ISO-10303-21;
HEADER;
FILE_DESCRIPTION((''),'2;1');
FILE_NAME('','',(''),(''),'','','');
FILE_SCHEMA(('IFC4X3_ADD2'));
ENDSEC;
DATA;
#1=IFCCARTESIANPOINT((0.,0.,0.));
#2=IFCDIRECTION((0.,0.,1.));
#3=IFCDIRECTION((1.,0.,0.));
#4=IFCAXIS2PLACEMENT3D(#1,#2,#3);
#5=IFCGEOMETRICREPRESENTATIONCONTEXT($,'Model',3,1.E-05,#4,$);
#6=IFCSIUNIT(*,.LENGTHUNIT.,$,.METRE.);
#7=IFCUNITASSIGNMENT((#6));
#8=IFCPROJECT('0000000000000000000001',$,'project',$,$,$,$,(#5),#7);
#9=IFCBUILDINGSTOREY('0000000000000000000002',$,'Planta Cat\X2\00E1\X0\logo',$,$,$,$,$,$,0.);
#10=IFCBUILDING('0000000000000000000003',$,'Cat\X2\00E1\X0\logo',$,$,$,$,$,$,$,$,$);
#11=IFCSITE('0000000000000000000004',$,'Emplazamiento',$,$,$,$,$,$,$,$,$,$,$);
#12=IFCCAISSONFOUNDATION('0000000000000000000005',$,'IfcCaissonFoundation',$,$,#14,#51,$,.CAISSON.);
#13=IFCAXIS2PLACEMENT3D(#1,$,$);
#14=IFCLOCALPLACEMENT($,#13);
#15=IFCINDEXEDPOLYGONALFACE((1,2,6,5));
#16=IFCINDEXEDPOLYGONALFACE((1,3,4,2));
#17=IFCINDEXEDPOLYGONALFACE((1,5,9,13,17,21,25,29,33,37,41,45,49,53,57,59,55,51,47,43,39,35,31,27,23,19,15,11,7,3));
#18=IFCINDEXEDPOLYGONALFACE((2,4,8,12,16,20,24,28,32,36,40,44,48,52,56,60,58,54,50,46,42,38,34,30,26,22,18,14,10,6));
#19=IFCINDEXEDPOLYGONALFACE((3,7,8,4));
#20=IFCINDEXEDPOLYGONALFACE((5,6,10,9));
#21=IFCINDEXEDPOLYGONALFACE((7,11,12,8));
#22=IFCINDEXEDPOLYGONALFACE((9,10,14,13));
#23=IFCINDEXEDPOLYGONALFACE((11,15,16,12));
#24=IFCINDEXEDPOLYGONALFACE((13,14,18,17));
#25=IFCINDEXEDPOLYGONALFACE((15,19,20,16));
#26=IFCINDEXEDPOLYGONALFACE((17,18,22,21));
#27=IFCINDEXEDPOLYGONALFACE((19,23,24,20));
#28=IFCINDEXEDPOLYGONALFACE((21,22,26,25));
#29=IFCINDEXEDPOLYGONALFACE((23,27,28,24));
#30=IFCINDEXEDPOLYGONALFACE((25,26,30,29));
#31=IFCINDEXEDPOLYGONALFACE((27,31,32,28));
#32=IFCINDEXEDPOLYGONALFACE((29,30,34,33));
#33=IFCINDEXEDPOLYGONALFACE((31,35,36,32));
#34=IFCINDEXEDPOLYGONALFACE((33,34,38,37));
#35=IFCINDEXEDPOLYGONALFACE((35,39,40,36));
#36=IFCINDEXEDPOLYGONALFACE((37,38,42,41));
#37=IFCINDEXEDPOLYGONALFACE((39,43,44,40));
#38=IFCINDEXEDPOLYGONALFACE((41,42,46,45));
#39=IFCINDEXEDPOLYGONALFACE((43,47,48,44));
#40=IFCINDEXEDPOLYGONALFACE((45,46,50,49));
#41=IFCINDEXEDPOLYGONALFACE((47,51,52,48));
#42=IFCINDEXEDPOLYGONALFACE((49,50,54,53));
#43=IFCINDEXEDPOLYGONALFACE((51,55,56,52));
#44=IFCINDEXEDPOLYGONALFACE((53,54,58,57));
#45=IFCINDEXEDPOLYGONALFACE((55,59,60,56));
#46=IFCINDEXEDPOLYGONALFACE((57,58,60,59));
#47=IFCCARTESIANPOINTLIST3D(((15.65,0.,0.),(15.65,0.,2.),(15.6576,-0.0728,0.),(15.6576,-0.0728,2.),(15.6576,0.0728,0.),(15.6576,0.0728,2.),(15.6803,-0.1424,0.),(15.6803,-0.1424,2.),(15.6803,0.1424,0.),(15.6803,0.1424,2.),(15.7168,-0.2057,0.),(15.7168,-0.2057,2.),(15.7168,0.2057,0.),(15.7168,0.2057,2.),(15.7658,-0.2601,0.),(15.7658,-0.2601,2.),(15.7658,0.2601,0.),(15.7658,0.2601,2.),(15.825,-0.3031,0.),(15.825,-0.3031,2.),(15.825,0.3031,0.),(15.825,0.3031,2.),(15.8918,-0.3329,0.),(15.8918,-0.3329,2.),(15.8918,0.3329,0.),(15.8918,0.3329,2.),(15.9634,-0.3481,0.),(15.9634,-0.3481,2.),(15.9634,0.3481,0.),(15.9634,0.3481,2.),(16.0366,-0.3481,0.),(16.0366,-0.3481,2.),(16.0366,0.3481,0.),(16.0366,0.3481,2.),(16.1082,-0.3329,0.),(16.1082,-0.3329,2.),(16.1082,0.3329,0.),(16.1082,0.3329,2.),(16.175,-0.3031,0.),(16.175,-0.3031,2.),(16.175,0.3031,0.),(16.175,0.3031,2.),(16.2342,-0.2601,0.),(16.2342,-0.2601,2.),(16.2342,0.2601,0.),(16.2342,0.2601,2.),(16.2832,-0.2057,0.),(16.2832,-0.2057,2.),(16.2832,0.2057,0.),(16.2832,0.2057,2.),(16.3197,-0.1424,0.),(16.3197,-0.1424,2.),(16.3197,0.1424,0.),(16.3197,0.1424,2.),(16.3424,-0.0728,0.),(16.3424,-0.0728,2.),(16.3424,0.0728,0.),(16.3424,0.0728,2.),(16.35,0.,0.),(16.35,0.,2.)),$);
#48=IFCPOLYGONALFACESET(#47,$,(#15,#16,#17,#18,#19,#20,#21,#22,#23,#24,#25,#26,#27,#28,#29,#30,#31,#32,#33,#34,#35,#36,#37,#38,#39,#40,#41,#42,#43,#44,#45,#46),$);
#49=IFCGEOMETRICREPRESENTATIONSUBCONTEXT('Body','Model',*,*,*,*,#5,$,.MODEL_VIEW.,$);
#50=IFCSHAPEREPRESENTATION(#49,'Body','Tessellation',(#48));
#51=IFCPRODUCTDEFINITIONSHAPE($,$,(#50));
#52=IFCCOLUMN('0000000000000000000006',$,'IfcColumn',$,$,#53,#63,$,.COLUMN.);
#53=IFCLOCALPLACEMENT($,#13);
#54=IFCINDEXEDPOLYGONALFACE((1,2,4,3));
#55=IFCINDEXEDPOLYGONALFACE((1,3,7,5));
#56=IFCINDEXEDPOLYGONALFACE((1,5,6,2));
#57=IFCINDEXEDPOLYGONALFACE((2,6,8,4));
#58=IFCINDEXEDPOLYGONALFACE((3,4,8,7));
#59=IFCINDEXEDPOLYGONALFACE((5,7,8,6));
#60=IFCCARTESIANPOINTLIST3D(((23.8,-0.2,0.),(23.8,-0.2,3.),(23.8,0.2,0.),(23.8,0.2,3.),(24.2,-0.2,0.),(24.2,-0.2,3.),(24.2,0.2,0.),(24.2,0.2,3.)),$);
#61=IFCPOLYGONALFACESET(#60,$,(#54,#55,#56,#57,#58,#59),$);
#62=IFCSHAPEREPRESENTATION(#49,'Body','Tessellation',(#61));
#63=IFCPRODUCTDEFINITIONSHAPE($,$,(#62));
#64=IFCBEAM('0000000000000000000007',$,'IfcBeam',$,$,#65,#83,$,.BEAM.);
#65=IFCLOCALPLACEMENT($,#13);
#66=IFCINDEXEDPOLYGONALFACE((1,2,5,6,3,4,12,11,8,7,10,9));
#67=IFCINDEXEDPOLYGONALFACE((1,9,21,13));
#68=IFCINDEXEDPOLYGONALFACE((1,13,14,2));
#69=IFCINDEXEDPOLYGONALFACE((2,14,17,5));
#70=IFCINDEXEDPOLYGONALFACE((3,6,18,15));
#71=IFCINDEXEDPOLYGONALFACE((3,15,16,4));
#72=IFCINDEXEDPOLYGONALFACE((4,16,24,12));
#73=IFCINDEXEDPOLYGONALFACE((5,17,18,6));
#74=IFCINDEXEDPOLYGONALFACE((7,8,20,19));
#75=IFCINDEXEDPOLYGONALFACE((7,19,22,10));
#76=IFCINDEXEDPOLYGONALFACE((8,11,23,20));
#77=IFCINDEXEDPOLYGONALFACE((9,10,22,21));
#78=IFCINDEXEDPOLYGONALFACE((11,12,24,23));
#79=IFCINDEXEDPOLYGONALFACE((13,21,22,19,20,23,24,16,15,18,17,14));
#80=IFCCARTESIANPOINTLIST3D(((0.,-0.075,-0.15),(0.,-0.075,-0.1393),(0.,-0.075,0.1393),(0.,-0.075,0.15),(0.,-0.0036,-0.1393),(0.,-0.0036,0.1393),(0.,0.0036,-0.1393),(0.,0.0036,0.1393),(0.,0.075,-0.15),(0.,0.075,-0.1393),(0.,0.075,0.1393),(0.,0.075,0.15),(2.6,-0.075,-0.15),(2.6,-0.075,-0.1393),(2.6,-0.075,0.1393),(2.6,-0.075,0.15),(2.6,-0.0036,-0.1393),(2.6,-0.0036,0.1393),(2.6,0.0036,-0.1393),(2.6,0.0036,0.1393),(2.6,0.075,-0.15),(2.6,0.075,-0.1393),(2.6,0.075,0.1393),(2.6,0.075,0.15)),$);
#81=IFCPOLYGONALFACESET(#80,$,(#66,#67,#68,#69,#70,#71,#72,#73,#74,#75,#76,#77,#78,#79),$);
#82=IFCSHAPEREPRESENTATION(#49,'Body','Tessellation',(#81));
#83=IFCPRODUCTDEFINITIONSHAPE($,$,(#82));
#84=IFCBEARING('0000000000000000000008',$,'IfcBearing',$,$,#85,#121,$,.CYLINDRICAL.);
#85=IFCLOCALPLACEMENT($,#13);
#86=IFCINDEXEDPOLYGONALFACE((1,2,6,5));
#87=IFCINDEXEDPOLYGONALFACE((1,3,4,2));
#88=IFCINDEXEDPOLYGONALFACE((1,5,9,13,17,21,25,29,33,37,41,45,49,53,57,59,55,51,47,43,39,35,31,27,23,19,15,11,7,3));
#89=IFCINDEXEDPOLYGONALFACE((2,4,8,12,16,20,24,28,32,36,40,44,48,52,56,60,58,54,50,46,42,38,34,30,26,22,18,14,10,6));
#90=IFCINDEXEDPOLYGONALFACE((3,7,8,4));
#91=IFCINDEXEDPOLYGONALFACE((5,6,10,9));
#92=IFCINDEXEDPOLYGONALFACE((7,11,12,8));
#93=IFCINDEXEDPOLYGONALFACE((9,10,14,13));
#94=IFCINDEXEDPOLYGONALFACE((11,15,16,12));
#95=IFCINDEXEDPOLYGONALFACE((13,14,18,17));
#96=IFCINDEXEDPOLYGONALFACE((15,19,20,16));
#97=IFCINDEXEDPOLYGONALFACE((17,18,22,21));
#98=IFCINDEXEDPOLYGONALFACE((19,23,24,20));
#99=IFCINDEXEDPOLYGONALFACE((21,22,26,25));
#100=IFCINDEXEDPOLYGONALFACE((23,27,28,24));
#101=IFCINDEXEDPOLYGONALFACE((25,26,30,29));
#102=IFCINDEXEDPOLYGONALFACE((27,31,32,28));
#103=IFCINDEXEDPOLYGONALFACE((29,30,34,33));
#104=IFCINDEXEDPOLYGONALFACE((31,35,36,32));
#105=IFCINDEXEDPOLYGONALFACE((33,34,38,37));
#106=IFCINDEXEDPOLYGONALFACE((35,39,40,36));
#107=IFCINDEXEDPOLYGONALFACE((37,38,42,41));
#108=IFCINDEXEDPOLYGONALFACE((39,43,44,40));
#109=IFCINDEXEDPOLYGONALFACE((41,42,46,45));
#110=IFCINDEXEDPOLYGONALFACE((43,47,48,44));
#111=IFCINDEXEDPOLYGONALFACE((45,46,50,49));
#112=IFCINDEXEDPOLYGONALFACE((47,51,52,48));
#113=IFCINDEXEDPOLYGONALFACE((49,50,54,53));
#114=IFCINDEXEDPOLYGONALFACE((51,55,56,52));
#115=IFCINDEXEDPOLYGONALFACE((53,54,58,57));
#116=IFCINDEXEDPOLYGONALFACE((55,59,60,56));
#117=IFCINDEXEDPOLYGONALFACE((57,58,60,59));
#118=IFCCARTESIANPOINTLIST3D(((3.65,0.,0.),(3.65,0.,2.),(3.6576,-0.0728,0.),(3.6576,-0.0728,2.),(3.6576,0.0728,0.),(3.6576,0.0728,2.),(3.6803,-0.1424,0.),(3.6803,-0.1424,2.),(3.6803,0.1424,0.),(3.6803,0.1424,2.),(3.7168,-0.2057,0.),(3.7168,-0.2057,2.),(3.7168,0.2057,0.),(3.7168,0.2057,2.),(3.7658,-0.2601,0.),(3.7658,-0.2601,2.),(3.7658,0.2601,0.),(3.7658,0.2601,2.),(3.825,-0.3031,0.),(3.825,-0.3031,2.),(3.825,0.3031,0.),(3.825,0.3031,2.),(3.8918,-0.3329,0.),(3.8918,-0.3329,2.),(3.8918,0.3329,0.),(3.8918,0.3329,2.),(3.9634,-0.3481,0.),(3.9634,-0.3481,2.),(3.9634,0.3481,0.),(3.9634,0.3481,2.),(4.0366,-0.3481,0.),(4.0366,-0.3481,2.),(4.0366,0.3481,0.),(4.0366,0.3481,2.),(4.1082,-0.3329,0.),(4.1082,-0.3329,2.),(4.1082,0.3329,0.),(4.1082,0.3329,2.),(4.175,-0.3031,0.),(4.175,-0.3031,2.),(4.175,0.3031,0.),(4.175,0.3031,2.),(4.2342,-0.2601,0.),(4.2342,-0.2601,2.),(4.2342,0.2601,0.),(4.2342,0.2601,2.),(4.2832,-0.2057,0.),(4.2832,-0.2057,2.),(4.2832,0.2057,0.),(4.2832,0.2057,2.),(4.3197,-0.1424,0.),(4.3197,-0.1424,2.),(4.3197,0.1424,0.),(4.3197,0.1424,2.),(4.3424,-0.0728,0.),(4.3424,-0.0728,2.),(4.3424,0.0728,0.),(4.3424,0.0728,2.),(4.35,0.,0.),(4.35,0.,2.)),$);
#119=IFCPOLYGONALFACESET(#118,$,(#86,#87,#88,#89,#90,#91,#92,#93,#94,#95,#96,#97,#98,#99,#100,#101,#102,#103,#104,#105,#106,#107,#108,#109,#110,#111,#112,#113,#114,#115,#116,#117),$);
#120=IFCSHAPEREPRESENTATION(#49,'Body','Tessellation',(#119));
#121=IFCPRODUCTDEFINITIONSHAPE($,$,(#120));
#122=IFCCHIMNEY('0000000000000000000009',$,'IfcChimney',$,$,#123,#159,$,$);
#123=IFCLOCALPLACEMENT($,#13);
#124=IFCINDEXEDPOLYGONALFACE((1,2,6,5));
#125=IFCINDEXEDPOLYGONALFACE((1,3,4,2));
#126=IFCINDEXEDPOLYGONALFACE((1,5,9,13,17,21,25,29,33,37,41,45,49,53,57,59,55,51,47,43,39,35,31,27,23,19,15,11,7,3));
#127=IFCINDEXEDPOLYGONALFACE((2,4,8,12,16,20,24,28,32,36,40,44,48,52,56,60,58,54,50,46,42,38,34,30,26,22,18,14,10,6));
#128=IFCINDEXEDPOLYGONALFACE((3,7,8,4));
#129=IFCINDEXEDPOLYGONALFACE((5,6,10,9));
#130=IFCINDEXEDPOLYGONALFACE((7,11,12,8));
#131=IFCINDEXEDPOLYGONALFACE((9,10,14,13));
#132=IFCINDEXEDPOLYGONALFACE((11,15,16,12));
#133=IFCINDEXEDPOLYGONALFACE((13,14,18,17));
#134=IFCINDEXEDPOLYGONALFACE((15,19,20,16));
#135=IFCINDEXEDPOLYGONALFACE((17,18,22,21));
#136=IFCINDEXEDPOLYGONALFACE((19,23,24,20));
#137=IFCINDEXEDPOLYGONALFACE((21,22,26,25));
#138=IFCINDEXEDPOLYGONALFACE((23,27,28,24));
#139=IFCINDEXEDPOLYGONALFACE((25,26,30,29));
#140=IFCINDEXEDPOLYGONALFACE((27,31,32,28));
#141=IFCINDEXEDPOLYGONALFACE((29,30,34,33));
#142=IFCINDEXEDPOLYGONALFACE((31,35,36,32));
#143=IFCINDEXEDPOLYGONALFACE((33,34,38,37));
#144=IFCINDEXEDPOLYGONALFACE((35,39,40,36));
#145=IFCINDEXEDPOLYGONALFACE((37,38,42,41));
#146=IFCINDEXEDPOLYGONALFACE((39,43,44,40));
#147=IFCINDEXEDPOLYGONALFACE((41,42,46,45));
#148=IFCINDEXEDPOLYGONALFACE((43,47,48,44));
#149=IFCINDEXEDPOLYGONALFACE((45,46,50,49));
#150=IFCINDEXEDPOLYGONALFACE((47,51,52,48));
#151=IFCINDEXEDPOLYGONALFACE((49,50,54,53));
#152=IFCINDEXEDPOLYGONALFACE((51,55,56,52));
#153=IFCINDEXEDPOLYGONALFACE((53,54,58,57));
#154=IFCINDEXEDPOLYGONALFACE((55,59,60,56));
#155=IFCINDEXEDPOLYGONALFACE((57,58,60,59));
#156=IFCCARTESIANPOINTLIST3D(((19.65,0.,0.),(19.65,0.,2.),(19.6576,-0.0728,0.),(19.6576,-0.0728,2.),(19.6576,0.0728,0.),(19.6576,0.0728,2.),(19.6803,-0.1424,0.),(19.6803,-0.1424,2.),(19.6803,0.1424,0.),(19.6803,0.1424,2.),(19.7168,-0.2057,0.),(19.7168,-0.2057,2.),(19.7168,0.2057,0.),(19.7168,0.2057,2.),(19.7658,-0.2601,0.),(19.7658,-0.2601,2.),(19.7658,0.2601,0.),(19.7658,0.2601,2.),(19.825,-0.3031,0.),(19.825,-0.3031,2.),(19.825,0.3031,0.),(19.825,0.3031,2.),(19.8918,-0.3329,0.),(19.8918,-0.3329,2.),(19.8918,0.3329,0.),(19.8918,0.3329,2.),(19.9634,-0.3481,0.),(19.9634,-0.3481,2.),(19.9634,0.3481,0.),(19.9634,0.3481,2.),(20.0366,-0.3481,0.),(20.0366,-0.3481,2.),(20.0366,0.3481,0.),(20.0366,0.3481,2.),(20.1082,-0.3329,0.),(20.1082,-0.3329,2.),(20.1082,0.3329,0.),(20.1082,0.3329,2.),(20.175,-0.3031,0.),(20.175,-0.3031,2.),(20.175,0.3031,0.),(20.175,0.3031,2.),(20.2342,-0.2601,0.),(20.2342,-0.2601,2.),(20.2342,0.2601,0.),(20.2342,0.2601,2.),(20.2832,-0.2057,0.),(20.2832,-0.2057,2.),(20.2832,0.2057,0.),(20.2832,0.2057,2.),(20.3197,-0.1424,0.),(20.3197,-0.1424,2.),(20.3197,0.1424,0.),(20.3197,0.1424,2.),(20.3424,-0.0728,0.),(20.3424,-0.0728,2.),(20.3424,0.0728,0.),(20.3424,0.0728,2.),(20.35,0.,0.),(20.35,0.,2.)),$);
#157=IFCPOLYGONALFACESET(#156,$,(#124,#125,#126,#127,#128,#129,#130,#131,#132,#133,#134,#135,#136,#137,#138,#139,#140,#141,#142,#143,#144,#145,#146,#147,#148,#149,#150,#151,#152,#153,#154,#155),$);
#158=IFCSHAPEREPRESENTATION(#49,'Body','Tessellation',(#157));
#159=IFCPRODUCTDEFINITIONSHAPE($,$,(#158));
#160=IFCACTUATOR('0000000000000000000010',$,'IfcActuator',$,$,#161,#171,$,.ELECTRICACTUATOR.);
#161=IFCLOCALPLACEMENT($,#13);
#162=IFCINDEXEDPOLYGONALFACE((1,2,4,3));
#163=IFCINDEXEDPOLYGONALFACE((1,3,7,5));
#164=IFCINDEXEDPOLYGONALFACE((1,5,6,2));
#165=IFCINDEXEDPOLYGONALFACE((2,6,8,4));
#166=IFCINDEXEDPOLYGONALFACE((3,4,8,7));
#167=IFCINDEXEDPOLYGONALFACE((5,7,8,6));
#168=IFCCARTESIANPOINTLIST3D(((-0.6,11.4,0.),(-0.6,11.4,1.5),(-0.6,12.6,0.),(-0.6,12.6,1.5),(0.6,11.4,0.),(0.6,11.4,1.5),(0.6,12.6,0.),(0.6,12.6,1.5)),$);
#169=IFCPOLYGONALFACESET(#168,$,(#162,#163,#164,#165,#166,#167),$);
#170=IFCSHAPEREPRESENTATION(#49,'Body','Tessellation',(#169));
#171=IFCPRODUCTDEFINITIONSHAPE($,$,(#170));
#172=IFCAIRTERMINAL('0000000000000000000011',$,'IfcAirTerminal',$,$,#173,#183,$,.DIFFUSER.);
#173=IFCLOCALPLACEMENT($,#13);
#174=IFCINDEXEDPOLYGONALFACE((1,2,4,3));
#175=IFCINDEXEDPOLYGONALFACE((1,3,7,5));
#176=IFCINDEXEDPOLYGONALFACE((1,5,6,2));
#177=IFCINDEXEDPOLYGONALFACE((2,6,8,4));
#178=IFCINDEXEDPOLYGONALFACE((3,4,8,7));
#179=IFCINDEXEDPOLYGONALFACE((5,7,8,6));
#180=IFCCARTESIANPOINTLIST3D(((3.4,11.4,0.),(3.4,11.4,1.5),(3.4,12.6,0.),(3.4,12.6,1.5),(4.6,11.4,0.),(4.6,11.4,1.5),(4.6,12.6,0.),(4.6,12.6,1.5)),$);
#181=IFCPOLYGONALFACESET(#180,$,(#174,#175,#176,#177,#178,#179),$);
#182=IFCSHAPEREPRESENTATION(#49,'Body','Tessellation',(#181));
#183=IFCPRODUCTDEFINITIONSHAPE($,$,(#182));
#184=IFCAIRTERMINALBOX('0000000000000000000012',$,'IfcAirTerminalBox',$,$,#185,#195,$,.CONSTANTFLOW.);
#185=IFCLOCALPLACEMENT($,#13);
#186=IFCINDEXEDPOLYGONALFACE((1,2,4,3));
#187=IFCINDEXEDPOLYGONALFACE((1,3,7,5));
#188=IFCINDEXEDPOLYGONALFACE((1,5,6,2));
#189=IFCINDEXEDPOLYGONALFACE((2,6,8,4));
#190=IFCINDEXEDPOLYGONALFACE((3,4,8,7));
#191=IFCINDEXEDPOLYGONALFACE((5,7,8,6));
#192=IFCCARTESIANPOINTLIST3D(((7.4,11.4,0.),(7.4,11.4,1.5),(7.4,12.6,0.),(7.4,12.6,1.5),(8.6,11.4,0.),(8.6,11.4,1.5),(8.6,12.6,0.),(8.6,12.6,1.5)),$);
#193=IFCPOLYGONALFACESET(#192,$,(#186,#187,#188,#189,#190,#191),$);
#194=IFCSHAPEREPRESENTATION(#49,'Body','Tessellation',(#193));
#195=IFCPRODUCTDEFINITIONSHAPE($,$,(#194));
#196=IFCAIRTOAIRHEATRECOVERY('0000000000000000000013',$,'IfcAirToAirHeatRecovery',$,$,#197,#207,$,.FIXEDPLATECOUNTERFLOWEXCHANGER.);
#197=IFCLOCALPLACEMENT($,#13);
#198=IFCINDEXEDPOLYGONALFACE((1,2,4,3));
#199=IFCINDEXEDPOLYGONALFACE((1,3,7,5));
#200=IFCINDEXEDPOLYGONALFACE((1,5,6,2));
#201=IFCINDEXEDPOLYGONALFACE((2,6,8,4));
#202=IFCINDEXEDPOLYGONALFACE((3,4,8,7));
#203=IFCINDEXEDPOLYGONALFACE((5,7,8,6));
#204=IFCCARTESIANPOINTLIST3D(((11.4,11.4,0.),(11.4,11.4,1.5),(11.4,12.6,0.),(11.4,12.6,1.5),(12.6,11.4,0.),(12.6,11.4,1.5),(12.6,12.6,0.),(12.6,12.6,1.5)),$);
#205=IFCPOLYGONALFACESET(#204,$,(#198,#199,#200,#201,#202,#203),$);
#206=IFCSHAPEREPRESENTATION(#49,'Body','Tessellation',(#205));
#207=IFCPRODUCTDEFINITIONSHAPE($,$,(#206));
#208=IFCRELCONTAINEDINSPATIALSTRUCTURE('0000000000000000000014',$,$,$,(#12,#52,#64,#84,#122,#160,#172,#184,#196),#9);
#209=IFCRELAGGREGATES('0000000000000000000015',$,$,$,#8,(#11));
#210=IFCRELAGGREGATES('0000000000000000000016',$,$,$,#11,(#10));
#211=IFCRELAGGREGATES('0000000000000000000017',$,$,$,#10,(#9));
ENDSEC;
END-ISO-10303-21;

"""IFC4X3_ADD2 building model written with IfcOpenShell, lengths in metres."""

from ifc_helpers import new_model, si_unit, frame, origin, origin_with_axes, origin_2d, place, context, subcontext, project, spatial, rectangle, circle, i_section, extrude, element, save


model = new_model("IFC4X3_ADD2")

# Units and contexts
model_context = context("Model", 3, precision=1e-05, world=origin_with_axes())
body_context = subcontext(model_context, "Body", "Model", "MODEL_VIEW")
ifc_project = project(units=[si_unit("LENGTHUNIT", "METRE")], contexts=[model_context])

# Site, building, storey
site = spatial("IfcSite", under=ifc_project, Name="Emplazamiento")
building = spatial("IfcBuilding", under=site, Name="Catálogo")
storey = spatial("IfcBuildingStorey", under=building, Name="Planta Catálogo", Elevation=0.0)

# Caisson foundation
caisson_foundation_placement = place(None, frame((16.0, 0.0, 0.0), z_axis=(0.0, 0.0, 1.0), x_axis=(1.0, 0.0, 0.0)))
element("IfcCaissonFoundation", 1, at=caisson_foundation_placement, inside=storey, Name="IfcCaissonFoundation", PredefinedType="CAISSON", context=body_context, shape_type="SweptSolid", body=[
    extrude(circle(Radius=0.35, at=origin_2d()), origin(), (0.0, 0.0, 1.0), 2.0),
])

# Column
column_placement = place(None, frame((24.0, 0.0, 0.0), z_axis=(0.0, 0.0, 1.0), x_axis=(1.0, 0.0, 0.0)))
element("IfcColumn", 2, at=column_placement, inside=storey, Name="IfcColumn", PredefinedType="COLUMN", context=body_context, shape_type="SweptSolid", body=[
    extrude(rectangle(XDim=0.4, YDim=0.4, at=origin_2d()), origin(), (0.0, 0.0, 1.0), 3.0),
])

# Beam
beam_placement = place(None, frame((0.0, 0.0, 0.0), z_axis=(1.0, 0.0, 0.0), x_axis=(0.0, 1.0, 0.0)))
element("IfcBeam", 3, at=beam_placement, inside=storey, Name="IfcBeam", PredefinedType="BEAM", context=body_context, shape_type="SweptSolid", body=[
    extrude(i_section(OverallWidth=0.15, OverallDepth=0.3, WebThickness=0.0071, FlangeThickness=0.0107, at=origin_2d()), origin(), (0.0, 0.0, 1.0), 2.6),
])

# Bearing
bearing_placement = place(None, frame((4.0, 0.0, 0.0), z_axis=(0.0, 0.0, 1.0), x_axis=(1.0, 0.0, 0.0)))
element("IfcBearing", 4, at=bearing_placement, inside=storey, Name="IfcBearing", PredefinedType="CYLINDRICAL", context=body_context, shape_type="SweptSolid", body=[
    extrude(circle(Radius=0.35, at=origin_2d()), origin(), (0.0, 0.0, 1.0), 2.0),
])

# Chimney
chimney_placement = place(None, frame((20.0, 0.0, 0.0), z_axis=(0.0, 0.0, 1.0), x_axis=(1.0, 0.0, 0.0)))
element("IfcChimney", 5, at=chimney_placement, inside=storey, Name="IfcChimney", context=body_context, shape_type="SweptSolid", body=[
    extrude(circle(Radius=0.35, at=origin_2d()), origin(), (0.0, 0.0, 1.0), 2.0),
])

# Actuator
actuator_placement = place(None, frame((0.0, 12.0, 0.0), z_axis=(0.0, 0.0, 1.0), x_axis=(1.0, 0.0, 0.0)))
element("IfcActuator", 6, at=actuator_placement, inside=storey, Name="IfcActuator", PredefinedType="ELECTRICACTUATOR", context=body_context, shape_type="SweptSolid", body=[
    extrude(rectangle(XDim=1.2, YDim=1.2, at=origin_2d()), origin(), (0.0, 0.0, 1.0), 1.5),
])

# Air terminal
air_terminal_placement = place(None, frame((4.0, 12.0, 0.0), z_axis=(0.0, 0.0, 1.0), x_axis=(1.0, 0.0, 0.0)))
element("IfcAirTerminal", 7, at=air_terminal_placement, inside=storey, Name="IfcAirTerminal", PredefinedType="DIFFUSER", context=body_context, shape_type="SweptSolid", body=[
    extrude(rectangle(XDim=1.2, YDim=1.2, at=origin_2d()), origin(), (0.0, 0.0, 1.0), 1.5),
])

# Air terminal box
air_terminal_box_placement = place(None, frame((8.0, 12.0, 0.0), z_axis=(0.0, 0.0, 1.0), x_axis=(1.0, 0.0, 0.0)))
element("IfcAirTerminalBox", 8, at=air_terminal_box_placement, inside=storey, Name="IfcAirTerminalBox", PredefinedType="CONSTANTFLOW", context=body_context, shape_type="SweptSolid", body=[
    extrude(rectangle(XDim=1.2, YDim=1.2, at=origin_2d()), origin(), (0.0, 0.0, 1.0), 1.5),
])

# Air to air heat recovery
air_to_air_heat_recovery_placement = place(None, frame((12.0, 12.0, 0.0), z_axis=(0.0, 0.0, 1.0), x_axis=(1.0, 0.0, 0.0)))
element("IfcAirToAirHeatRecovery", 9, at=air_to_air_heat_recovery_placement, inside=storey, Name="IfcAirToAirHeatRecovery", PredefinedType="FIXEDPLATECOUNTERFLOWEXCHANGER", context=body_context, shape_type="SweptSolid", body=[
    extrude(rectangle(XDim=1.2, YDim=1.2, at=origin_2d()), origin(), (0.0, 0.0, 1.0), 1.5),
])

save(model, "model.ifc")
